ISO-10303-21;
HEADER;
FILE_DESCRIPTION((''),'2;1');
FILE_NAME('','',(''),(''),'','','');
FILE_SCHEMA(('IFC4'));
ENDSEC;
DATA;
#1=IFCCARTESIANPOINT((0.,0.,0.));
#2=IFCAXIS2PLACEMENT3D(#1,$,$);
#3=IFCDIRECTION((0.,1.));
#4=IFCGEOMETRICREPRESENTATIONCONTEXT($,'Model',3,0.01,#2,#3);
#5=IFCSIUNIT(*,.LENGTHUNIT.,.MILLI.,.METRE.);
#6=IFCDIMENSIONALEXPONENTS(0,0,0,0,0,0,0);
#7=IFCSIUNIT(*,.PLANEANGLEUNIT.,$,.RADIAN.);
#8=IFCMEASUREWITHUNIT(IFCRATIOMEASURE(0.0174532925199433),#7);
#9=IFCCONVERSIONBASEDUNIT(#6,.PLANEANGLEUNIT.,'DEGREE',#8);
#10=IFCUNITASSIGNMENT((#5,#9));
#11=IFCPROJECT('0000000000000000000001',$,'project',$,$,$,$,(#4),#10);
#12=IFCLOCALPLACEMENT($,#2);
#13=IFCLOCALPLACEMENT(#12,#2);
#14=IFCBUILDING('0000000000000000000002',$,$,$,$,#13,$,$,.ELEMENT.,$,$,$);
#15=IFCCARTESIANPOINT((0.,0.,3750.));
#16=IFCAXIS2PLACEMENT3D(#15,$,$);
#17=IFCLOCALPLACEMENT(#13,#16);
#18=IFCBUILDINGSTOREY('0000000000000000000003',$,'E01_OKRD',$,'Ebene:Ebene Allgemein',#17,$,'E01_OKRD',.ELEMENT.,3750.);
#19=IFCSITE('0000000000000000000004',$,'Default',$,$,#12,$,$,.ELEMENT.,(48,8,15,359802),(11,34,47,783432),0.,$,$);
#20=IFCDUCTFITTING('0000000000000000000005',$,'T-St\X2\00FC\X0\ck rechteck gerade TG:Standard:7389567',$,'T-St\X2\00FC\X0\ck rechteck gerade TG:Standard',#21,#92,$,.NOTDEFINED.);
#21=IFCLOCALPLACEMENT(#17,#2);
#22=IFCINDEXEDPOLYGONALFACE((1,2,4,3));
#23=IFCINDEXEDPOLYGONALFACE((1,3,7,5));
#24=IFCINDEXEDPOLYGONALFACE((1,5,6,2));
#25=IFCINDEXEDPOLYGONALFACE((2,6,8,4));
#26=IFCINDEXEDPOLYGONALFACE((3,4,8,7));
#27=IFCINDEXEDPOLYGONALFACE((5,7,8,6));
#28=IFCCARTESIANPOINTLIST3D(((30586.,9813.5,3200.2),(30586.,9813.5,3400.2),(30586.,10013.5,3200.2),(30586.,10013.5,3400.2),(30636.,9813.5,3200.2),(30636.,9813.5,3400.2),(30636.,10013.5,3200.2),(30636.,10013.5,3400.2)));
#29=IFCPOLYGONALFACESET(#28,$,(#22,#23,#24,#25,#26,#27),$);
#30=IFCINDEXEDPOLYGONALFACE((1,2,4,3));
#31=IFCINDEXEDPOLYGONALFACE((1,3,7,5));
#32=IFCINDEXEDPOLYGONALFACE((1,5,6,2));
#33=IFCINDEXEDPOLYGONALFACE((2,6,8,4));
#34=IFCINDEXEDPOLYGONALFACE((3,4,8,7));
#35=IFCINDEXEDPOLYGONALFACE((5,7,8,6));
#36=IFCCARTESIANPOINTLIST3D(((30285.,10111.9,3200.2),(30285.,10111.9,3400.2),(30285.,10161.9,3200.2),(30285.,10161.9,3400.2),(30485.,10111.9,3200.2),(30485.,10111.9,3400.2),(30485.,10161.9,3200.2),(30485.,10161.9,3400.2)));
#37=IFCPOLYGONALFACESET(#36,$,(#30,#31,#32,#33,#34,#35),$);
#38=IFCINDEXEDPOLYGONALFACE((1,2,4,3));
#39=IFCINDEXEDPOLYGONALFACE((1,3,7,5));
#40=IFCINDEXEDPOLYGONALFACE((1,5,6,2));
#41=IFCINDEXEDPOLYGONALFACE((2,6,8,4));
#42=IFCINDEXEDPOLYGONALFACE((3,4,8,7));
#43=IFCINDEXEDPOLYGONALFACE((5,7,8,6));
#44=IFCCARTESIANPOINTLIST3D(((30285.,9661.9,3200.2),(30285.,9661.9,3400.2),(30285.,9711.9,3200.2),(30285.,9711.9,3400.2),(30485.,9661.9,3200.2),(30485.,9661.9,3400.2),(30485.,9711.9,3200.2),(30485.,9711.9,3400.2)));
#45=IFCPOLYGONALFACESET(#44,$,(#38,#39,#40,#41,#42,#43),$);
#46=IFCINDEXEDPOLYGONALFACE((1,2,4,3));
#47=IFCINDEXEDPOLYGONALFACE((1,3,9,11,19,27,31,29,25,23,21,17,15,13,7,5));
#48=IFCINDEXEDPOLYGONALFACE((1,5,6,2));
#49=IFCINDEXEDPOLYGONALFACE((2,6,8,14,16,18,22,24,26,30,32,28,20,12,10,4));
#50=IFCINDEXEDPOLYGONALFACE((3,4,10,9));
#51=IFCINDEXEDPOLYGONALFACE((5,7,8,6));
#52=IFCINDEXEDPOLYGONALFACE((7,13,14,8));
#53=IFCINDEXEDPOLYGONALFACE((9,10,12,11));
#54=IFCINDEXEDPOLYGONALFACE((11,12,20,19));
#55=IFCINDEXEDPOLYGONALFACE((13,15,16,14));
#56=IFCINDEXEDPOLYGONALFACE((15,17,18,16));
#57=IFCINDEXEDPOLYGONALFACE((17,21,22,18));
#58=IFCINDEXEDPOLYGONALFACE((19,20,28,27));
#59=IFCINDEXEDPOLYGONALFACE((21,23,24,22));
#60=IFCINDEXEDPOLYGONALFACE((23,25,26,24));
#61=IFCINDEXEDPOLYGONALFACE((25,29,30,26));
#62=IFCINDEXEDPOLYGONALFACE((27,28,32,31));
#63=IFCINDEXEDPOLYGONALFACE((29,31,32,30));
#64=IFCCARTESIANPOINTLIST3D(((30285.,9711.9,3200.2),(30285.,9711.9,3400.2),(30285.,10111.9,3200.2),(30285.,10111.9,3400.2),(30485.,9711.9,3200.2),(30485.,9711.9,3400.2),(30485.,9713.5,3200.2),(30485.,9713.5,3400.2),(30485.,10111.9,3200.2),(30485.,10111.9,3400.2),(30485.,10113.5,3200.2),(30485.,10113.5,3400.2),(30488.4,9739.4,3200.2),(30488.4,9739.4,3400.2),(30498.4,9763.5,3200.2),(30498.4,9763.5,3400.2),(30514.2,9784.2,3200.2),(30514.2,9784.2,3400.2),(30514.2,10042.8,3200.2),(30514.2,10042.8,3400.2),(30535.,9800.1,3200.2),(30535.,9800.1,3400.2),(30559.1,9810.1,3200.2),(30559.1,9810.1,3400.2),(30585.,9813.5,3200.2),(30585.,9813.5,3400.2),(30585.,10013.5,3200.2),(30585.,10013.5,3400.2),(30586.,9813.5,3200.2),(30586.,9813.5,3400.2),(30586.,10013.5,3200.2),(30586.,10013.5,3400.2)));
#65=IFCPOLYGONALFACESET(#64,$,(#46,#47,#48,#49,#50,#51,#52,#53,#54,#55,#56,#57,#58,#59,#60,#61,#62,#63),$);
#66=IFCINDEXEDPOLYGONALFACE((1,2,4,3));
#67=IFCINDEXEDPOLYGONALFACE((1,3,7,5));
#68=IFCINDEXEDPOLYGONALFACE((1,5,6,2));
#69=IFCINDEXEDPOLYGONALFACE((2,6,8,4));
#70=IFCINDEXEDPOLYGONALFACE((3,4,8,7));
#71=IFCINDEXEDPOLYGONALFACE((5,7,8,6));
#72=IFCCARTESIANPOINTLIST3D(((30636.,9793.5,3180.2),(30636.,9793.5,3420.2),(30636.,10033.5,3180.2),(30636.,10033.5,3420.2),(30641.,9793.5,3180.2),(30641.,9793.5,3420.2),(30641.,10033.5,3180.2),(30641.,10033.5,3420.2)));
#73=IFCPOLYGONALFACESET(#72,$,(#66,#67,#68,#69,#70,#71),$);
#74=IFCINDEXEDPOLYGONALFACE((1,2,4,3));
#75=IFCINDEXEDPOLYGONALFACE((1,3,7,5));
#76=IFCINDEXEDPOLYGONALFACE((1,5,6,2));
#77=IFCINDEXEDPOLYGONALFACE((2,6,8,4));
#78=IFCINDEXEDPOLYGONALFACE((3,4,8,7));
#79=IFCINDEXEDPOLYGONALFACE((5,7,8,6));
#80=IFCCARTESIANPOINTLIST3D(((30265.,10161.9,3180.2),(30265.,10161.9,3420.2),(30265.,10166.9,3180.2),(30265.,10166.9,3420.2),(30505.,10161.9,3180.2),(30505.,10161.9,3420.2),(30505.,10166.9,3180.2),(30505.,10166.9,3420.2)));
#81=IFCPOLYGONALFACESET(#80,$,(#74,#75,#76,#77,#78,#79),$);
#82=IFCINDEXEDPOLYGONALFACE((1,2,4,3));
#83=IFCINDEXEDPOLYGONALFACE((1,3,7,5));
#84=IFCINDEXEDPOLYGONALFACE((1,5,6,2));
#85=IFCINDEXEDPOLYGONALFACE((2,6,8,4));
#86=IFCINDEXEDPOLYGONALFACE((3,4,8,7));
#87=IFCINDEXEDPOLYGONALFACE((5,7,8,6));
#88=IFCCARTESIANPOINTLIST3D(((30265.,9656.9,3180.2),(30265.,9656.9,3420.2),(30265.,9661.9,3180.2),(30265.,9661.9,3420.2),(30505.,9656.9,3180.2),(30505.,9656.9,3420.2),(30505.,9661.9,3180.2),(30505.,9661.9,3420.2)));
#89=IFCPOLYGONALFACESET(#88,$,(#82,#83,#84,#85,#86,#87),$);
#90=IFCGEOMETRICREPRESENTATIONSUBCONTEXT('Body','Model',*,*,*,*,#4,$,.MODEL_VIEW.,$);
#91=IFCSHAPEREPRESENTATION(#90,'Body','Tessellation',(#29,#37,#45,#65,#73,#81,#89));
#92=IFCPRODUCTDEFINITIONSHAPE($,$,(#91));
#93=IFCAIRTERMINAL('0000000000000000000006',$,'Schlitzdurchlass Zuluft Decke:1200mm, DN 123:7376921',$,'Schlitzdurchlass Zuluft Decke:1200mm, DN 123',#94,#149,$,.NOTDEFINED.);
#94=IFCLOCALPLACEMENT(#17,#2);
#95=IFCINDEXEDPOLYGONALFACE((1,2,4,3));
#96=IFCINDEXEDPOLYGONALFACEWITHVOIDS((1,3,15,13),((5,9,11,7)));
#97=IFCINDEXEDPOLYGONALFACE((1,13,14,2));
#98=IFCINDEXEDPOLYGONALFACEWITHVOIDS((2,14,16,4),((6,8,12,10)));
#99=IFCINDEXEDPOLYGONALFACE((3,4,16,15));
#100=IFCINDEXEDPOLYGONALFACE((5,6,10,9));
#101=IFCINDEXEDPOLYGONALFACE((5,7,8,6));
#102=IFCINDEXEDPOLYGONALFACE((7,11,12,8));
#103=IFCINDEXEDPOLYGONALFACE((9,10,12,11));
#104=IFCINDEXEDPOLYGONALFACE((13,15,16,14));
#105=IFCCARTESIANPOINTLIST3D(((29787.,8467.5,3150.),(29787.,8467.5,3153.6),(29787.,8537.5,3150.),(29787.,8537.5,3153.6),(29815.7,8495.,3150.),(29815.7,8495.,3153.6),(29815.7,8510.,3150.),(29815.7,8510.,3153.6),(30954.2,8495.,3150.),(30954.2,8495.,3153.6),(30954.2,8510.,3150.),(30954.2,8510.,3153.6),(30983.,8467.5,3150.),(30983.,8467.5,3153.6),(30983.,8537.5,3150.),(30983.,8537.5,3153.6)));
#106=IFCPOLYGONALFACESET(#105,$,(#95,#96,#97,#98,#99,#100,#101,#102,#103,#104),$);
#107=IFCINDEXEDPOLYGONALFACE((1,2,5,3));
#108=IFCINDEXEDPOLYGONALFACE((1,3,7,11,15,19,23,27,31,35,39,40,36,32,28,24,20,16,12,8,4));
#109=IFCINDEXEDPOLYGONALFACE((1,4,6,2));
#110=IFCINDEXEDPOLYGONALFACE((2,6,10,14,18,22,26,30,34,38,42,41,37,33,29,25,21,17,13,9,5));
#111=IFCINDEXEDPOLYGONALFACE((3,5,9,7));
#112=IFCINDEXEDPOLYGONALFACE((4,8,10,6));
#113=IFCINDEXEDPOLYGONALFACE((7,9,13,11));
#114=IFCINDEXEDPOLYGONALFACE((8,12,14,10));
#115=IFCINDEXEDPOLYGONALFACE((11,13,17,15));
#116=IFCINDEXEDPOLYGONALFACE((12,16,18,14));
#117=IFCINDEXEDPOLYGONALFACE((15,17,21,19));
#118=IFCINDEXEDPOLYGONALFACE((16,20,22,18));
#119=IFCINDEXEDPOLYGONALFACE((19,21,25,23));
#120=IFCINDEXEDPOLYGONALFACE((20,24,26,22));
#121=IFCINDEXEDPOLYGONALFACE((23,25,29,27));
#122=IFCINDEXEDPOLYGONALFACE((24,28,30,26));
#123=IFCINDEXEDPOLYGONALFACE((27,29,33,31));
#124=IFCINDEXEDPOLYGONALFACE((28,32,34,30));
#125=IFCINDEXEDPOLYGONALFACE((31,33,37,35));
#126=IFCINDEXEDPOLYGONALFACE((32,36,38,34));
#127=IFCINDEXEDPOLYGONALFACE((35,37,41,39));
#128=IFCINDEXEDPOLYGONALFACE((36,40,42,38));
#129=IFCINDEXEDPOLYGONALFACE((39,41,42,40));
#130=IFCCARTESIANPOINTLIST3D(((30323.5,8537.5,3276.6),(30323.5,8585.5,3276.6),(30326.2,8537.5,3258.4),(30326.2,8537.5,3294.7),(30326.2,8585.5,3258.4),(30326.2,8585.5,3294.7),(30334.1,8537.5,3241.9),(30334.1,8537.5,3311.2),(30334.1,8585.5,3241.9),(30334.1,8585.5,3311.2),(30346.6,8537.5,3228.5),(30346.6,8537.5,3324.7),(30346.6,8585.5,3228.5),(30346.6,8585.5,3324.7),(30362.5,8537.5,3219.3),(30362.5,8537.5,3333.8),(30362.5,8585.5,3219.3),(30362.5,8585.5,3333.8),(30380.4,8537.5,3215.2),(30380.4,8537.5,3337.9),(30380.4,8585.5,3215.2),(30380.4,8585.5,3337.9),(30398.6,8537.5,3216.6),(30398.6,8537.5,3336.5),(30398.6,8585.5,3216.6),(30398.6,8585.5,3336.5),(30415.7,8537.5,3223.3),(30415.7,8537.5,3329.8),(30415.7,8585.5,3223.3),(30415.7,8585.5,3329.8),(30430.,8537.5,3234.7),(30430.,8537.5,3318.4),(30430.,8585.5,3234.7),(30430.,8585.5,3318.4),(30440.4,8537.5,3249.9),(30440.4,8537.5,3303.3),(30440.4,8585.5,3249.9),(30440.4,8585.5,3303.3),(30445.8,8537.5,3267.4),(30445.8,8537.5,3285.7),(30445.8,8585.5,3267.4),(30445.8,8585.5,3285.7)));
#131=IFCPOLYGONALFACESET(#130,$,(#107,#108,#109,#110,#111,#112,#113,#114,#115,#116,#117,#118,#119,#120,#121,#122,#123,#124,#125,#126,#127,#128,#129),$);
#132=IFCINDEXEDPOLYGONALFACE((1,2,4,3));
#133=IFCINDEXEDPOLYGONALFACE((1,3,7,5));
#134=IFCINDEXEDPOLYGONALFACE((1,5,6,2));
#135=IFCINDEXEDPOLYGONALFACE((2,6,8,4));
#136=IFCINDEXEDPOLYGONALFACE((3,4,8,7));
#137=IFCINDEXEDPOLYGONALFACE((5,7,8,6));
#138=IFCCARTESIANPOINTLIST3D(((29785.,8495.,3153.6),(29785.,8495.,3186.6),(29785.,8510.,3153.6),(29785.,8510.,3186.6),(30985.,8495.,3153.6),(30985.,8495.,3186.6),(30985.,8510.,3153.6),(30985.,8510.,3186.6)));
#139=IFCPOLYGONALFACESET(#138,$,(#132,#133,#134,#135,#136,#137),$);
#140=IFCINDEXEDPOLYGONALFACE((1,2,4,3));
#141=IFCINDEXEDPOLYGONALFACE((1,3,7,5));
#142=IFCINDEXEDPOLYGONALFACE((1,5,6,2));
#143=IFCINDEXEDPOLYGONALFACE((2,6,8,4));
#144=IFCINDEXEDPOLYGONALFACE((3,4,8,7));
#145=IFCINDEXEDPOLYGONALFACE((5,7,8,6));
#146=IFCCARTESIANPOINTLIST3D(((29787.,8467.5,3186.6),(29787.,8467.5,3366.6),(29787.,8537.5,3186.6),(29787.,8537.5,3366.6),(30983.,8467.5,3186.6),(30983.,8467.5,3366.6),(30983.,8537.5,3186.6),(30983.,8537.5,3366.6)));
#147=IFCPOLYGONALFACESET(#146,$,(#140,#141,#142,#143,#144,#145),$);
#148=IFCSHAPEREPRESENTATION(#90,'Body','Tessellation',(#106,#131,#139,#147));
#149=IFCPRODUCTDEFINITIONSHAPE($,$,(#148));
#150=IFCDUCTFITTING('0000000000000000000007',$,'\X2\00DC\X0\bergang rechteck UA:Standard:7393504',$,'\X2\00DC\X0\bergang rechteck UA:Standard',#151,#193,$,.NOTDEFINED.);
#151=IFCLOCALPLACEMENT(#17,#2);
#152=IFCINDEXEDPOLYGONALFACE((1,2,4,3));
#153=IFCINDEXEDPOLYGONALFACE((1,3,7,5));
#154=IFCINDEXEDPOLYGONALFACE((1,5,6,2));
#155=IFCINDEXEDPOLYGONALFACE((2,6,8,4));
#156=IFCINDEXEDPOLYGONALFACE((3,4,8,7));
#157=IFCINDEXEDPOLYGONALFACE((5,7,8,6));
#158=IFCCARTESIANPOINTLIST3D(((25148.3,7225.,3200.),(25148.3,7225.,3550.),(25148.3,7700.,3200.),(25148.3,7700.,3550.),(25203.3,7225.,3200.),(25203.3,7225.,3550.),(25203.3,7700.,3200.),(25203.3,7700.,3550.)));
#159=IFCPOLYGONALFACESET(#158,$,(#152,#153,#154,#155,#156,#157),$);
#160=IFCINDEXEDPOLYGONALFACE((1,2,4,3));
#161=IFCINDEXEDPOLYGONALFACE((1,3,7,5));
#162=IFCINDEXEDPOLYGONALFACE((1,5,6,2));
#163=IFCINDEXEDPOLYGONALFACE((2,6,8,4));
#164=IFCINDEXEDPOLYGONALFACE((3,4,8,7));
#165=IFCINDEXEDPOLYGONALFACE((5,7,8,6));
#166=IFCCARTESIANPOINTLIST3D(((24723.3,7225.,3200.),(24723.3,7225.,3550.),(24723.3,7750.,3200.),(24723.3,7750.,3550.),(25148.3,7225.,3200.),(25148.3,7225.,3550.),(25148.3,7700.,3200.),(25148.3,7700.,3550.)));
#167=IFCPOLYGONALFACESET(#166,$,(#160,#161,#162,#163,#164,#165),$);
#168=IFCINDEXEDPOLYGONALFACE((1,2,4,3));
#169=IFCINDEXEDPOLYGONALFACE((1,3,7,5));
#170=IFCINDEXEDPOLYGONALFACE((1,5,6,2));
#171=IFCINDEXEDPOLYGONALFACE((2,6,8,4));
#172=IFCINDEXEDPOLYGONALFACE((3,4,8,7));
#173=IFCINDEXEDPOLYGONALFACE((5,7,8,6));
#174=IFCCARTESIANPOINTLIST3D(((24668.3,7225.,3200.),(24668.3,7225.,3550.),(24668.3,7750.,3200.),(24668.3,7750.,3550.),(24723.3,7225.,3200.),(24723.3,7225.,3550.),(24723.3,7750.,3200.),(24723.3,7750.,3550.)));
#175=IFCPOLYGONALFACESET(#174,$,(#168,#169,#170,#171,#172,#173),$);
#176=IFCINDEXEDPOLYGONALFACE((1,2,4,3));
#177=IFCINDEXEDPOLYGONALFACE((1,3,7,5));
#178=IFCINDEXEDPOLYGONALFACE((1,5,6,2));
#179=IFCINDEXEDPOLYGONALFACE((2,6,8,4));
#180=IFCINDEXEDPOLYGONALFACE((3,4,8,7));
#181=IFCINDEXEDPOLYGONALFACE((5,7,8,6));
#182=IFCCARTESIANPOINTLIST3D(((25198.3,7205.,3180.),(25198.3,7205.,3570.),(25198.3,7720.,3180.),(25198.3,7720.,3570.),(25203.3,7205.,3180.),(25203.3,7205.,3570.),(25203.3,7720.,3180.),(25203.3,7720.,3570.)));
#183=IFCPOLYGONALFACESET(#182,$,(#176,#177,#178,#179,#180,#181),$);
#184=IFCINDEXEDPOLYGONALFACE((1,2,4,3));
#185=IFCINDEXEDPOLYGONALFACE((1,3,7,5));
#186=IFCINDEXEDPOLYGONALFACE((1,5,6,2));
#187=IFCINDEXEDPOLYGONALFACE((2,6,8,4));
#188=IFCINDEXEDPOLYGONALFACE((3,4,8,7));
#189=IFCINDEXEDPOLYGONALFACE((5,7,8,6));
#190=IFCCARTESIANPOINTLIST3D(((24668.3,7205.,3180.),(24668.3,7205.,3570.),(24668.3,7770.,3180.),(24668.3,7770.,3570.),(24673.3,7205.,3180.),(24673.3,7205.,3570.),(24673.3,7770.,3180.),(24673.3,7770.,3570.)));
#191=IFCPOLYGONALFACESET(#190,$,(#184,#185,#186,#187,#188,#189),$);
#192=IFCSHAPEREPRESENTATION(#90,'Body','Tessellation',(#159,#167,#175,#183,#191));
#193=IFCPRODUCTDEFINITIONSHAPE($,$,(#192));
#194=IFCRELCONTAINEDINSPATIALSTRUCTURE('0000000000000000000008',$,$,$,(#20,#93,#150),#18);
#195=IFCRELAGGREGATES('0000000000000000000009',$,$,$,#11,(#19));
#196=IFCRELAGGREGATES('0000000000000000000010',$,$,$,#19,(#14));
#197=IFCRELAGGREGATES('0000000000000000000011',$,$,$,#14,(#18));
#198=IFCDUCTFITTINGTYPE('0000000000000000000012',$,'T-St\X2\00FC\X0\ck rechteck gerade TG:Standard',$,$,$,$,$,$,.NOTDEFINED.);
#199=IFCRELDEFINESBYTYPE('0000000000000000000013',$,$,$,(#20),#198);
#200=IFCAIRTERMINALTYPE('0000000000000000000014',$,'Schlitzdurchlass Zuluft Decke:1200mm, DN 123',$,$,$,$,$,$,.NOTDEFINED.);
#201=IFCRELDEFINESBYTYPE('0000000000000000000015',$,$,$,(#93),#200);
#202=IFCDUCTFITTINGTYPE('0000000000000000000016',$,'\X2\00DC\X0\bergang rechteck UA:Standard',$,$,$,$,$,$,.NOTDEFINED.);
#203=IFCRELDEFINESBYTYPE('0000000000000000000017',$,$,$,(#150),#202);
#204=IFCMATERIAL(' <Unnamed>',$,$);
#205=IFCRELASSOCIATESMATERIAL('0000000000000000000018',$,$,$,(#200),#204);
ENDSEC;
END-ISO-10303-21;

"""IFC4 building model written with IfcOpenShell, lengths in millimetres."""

from ifc_helpers import new_model, entity, si_unit, converted_unit, direction, frame, frame_2d, origin, origin_2d_with_axis, place, context, subcontext, project, spatial, polyline, circle_curve, parameter, trimmed, segment, composite_curve, rectangle, circle, outline, extrude, source, transform, mapped, material, type_object, type_shapes, element, save


model = new_model("IFC4")

# Units and contexts
model_context = context("Model", 3, precision=0.01, world=origin(), true_north=direction((0.0, 1.0)))
body_context = subcontext(model_context, "Body", "Model", "MODEL_VIEW")
ifc_project = project(units=[si_unit("LENGTHUNIT", "METRE", prefix="MILLI"), converted_unit("PLANEANGLEUNIT", "DEGREE", entity("IfcRatioMeasure", 0.0174532925199433), si_unit("PLANEANGLEUNIT", "RADIAN"), dimensions=[0, 0, 0, 0, 0, 0, 0])], contexts=[model_context])

# Site, building, storey
site_placement = place(None, origin())
site = spatial("IfcSite", under=ifc_project, at=site_placement, Name="Default", CompositionType="ELEMENT", RefLatitude=(48, 8, 15, 359802), RefLongitude=(11, 34, 47, 783432), RefElevation=0.0)
building_placement = place(site_placement, origin())
building = spatial("IfcBuilding", under=site, at=building_placement, CompositionType="ELEMENT")
storey_placement = place(building_placement, frame((0.0, 0.0, 3750.0)))
storey = spatial("IfcBuildingStorey", under=building, at=storey_placement, Name="E01_OKRD", ObjectType="Ebene:Ebene Allgemein", LongName="E01_OKRD", CompositionType="ELEMENT", Elevation=3750.0)

# Shared definitions
ifc_material_1 = material(Name=" <Unnamed>")

# Duct fitting
duct_fitting_type_1 = type_object("IfcDuctFittingType", Name="T-Stück rechteck gerade TG:Standard", PredefinedType="NOTDEFINED")
shared_shape_1 = source(origin(), body_context, "Body", "SweptSolid", [
    extrude(rectangle(XDim=50.0, YDim=200.0, at=frame_2d((0.0, 0.0), x_axis=(1.0, 0.0))), frame((0.0, -226.0, -100.0), z_axis=(0.0, 0.0, 1.0), x_axis=(0.0, -1.0, 0.0)), (0.0, 0.0, 1.0), 200.0),
    extrude(rectangle(XDim=50.0, YDim=200.0, at=frame_2d((0.0, 0.0), x_axis=(1.0, 0.0))), frame((223.4, 0.0, -100.0), z_axis=(0.0, 0.0, 1.0), x_axis=(-1.0, 0.0, 0.0)), (0.0, 0.0, 1.0), 200.0),
    extrude(rectangle(XDim=50.0, YDim=200.0, at=frame_2d((0.0, 0.0), x_axis=(1.0, 0.0))), frame((-226.6, 0.0, -100.0)), (0.0, 0.0, 1.0), 200.0),
    extrude(outline(composite_curve([segment(trimmed(circle_curve(frame_2d((-200.6, -99.8), x_axis=(-1.0, 0.0)), 100.0), [parameter(180.0)], [parameter(270.0)], True, "PARAMETER"), False, "CONTINUOUS"), segment(polyline([(-100.6, -99.8), (-100.6, -100.8)]), True, "CONTINUOUS"), segment(polyline([(-100.6, -100.8), (99.4, -100.8)]), True, "CONTINUOUS"), segment(polyline([(99.4, -100.8), (99.4, -99.8)]), True, "CONTINUOUS"), segment(trimmed(circle_curve(frame_2d((199.4, -99.8), x_axis=(-1.0, 0.0)), 100.0), [parameter(270.0)], [parameter(0.0)], True, "PARAMETER"), False, "CONTINUOUS"), segment(polyline([(199.4, 0.2), (201.0, 0.2)]), True, "CONTINUOUS"), segment(polyline([(201.0, 0.2), (201.0, 200.2)]), True, "CONTINUOUS"), segment(polyline([(201.0, 200.2), (-199.0, 200.2)]), True, "CONTINUOUS"), segment(polyline([(-199.0, 200.2), (-199.0, 0.2)]), True, "CONTINUOUS"), segment(polyline([(-199.0, 0.2), (-200.6, 0.2)]), True, "CONTINUOUS")], self_intersect=False)), frame((-0.6, -100.2, -100.0), z_axis=(0.0, 0.0, -1.0), x_axis=(-1.0, 0.0, 0.0)), (0.0, 0.0, -1.0), 200.0),
    extrude(rectangle(XDim=5.0, YDim=240.0, at=frame_2d((0.0, 0.0), x_axis=(1.0, 0.0))), frame((0.0, -253.5, -120.0), z_axis=(0.0, 0.0, 1.0), x_axis=(0.0, 1.0, 0.0)), (0.0, 0.0, 1.0), 240.0),
    extrude(rectangle(XDim=5.0, YDim=240.0, at=origin_2d_with_axis()), frame((250.9, 0.0, -120.0), z_axis=(0.0, 0.0, 1.0), x_axis=(-1.0, 0.0, 0.0)), (0.0, 0.0, 1.0), 240.0),
    extrude(rectangle(XDim=5.0, YDim=240.0, at=origin_2d_with_axis()), frame((-254.1, 0.0, -120.0), z_axis=(0.0, 0.0, 1.0), x_axis=(-1.0, 0.0, 0.0)), (0.0, 0.0, 1.0), 240.0),
])
type_shapes(duct_fitting_type_1, [shared_shape_1])
duct_fitting_1_placement = place(storey_placement, frame((30385.0, 9913.5, 3300.2), z_axis=(0.0, 0.0, 1.0), x_axis=(0.0, 1.0, 0.0)))
element("IfcDuctFitting", 1, at=duct_fitting_1_placement, inside=storey, type_object=duct_fitting_type_1, Name="T-Stück rechteck gerade TG:Standard:7389567", ObjectType="T-Stück rechteck gerade TG:Standard", PredefinedType="NOTDEFINED", context=body_context, shape_type="MappedRepresentation", body=[
    mapped(shared_shape_1, transform((0.0, 0.0, 0.0), scale=1.0)),
])

# Air terminal
air_terminal_type_1 = type_object("IfcAirTerminalType", Name="Schlitzdurchlass Zuluft Decke:1200mm, DN 123", PredefinedType="NOTDEFINED", material=ifc_material_1)
shared_shape_2 = source(origin(), body_context, "Body", "SweptSolid", [
    extrude(outline(polyline([(-598.0, -35.0), (598.0, -35.0), (598.0, 35.0), (-598.0, 35.0), (-598.0, -35.0)]), holes=[polyline([(-569.2, -7.5), (-569.2, 7.5), (569.2, 7.5), (569.2, -7.5), (-569.2, -7.5)])]), frame((600.0, 35.0, 0.0), z_axis=(0.0, 0.0, 1.0), x_axis=(-1.0, 0.0, 0.0)), (0.0, 0.0, 1.0), 3.6),
    extrude(circle(Radius=61.5, at=frame_2d((0.0, 0.0), x_axis=(1.0, 0.0))), frame((600.0, 70.0, 126.6), z_axis=(0.0, 1.0, 0.0), x_axis=(-1.0, 0.0, 0.0)), (0.0, 0.0, 1.0), 48.0),
    extrude(rectangle(XDim=1200.0, YDim=15.0, at=origin_2d_with_axis()), frame((600.0, 35.0, 3.6), z_axis=(0.0, 0.0, 1.0), x_axis=(-1.0, 0.0, 0.0)), (0.0, 0.0, 1.0), 33.0),
    extrude(rectangle(XDim=1196.0, YDim=70.0, at=origin_2d_with_axis()), frame((600.0, 35.0, 36.6), z_axis=(0.0, 0.0, 1.0), x_axis=(-1.0, 0.0, 0.0)), (0.0, 0.0, 1.0), 180.0),
])
type_shapes(air_terminal_type_1, [shared_shape_2])
air_terminal_1_placement = place(storey_placement, frame((29785.0, 8467.5, 3150.0)))
element("IfcAirTerminal", 2, at=air_terminal_1_placement, inside=storey, type_object=air_terminal_type_1, Name="Schlitzdurchlass Zuluft Decke:1200mm, DN 123:7376921", ObjectType="Schlitzdurchlass Zuluft Decke:1200mm, DN 123", PredefinedType="NOTDEFINED", context=body_context, shape_type="MappedRepresentation", body=[
    mapped(shared_shape_2, transform((0.0, 0.0, 0.0), scale=1.0)),
])

# Duct fitting
duct_fitting_type_2 = type_object("IfcDuctFittingType", Name="Übergang rechteck UA:Standard", PredefinedType="NOTDEFINED")
shared_shape_3 = source(origin(), body_context, "Body", "SweptSolid", [
    extrude(rectangle(XDim=55.0, YDim=475.0, at=frame_2d((0.0, 0.0), x_axis=(1.0, 0.0))), frame((507.5, -25.0, -175.0)), (0.0, 0.0, 1.0), 350.0),
    extrude(outline(polyline([(-212.5, -250.0), (212.5, -250.0), (212.5, 225.0), (-212.5, 275.0), (-212.5, -250.0)])), frame((267.5, -12.5, -175.0)), (0.0, 0.0, 1.0), 350.0),
    extrude(rectangle(XDim=55.0, YDim=525.0, at=frame_2d((0.0, 0.0), x_axis=(1.0, 0.0))), frame((27.5, 0.0, -175.0)), (0.0, 0.0, 1.0), 350.0),
    extrude(rectangle(XDim=5.0, YDim=515.0, at=origin_2d_with_axis()), frame((532.5, -25.0, -195.0)), (0.0, 0.0, 1.0), 390.0),
    extrude(rectangle(XDim=5.0, YDim=565.0, at=frame_2d((0.0, 0.0), x_axis=(1.0, 0.0))), frame((2.5, 0.0, -195.0)), (0.0, 0.0, 1.0), 390.0),
])
type_shapes(duct_fitting_type_2, [shared_shape_3])
duct_fitting_2_placement = place(storey_placement, frame((24668.3, 7487.5, 3375.0)))
element("IfcDuctFitting", 3, at=duct_fitting_2_placement, inside=storey, type_object=duct_fitting_type_2, Name="Übergang rechteck UA:Standard:7393504", ObjectType="Übergang rechteck UA:Standard", PredefinedType="NOTDEFINED", context=body_context, shape_type="MappedRepresentation", body=[
    mapped(shared_shape_3, transform((0.0, 0.0, 0.0), scale=1.0)),
])

save(model, "model.ifc")
